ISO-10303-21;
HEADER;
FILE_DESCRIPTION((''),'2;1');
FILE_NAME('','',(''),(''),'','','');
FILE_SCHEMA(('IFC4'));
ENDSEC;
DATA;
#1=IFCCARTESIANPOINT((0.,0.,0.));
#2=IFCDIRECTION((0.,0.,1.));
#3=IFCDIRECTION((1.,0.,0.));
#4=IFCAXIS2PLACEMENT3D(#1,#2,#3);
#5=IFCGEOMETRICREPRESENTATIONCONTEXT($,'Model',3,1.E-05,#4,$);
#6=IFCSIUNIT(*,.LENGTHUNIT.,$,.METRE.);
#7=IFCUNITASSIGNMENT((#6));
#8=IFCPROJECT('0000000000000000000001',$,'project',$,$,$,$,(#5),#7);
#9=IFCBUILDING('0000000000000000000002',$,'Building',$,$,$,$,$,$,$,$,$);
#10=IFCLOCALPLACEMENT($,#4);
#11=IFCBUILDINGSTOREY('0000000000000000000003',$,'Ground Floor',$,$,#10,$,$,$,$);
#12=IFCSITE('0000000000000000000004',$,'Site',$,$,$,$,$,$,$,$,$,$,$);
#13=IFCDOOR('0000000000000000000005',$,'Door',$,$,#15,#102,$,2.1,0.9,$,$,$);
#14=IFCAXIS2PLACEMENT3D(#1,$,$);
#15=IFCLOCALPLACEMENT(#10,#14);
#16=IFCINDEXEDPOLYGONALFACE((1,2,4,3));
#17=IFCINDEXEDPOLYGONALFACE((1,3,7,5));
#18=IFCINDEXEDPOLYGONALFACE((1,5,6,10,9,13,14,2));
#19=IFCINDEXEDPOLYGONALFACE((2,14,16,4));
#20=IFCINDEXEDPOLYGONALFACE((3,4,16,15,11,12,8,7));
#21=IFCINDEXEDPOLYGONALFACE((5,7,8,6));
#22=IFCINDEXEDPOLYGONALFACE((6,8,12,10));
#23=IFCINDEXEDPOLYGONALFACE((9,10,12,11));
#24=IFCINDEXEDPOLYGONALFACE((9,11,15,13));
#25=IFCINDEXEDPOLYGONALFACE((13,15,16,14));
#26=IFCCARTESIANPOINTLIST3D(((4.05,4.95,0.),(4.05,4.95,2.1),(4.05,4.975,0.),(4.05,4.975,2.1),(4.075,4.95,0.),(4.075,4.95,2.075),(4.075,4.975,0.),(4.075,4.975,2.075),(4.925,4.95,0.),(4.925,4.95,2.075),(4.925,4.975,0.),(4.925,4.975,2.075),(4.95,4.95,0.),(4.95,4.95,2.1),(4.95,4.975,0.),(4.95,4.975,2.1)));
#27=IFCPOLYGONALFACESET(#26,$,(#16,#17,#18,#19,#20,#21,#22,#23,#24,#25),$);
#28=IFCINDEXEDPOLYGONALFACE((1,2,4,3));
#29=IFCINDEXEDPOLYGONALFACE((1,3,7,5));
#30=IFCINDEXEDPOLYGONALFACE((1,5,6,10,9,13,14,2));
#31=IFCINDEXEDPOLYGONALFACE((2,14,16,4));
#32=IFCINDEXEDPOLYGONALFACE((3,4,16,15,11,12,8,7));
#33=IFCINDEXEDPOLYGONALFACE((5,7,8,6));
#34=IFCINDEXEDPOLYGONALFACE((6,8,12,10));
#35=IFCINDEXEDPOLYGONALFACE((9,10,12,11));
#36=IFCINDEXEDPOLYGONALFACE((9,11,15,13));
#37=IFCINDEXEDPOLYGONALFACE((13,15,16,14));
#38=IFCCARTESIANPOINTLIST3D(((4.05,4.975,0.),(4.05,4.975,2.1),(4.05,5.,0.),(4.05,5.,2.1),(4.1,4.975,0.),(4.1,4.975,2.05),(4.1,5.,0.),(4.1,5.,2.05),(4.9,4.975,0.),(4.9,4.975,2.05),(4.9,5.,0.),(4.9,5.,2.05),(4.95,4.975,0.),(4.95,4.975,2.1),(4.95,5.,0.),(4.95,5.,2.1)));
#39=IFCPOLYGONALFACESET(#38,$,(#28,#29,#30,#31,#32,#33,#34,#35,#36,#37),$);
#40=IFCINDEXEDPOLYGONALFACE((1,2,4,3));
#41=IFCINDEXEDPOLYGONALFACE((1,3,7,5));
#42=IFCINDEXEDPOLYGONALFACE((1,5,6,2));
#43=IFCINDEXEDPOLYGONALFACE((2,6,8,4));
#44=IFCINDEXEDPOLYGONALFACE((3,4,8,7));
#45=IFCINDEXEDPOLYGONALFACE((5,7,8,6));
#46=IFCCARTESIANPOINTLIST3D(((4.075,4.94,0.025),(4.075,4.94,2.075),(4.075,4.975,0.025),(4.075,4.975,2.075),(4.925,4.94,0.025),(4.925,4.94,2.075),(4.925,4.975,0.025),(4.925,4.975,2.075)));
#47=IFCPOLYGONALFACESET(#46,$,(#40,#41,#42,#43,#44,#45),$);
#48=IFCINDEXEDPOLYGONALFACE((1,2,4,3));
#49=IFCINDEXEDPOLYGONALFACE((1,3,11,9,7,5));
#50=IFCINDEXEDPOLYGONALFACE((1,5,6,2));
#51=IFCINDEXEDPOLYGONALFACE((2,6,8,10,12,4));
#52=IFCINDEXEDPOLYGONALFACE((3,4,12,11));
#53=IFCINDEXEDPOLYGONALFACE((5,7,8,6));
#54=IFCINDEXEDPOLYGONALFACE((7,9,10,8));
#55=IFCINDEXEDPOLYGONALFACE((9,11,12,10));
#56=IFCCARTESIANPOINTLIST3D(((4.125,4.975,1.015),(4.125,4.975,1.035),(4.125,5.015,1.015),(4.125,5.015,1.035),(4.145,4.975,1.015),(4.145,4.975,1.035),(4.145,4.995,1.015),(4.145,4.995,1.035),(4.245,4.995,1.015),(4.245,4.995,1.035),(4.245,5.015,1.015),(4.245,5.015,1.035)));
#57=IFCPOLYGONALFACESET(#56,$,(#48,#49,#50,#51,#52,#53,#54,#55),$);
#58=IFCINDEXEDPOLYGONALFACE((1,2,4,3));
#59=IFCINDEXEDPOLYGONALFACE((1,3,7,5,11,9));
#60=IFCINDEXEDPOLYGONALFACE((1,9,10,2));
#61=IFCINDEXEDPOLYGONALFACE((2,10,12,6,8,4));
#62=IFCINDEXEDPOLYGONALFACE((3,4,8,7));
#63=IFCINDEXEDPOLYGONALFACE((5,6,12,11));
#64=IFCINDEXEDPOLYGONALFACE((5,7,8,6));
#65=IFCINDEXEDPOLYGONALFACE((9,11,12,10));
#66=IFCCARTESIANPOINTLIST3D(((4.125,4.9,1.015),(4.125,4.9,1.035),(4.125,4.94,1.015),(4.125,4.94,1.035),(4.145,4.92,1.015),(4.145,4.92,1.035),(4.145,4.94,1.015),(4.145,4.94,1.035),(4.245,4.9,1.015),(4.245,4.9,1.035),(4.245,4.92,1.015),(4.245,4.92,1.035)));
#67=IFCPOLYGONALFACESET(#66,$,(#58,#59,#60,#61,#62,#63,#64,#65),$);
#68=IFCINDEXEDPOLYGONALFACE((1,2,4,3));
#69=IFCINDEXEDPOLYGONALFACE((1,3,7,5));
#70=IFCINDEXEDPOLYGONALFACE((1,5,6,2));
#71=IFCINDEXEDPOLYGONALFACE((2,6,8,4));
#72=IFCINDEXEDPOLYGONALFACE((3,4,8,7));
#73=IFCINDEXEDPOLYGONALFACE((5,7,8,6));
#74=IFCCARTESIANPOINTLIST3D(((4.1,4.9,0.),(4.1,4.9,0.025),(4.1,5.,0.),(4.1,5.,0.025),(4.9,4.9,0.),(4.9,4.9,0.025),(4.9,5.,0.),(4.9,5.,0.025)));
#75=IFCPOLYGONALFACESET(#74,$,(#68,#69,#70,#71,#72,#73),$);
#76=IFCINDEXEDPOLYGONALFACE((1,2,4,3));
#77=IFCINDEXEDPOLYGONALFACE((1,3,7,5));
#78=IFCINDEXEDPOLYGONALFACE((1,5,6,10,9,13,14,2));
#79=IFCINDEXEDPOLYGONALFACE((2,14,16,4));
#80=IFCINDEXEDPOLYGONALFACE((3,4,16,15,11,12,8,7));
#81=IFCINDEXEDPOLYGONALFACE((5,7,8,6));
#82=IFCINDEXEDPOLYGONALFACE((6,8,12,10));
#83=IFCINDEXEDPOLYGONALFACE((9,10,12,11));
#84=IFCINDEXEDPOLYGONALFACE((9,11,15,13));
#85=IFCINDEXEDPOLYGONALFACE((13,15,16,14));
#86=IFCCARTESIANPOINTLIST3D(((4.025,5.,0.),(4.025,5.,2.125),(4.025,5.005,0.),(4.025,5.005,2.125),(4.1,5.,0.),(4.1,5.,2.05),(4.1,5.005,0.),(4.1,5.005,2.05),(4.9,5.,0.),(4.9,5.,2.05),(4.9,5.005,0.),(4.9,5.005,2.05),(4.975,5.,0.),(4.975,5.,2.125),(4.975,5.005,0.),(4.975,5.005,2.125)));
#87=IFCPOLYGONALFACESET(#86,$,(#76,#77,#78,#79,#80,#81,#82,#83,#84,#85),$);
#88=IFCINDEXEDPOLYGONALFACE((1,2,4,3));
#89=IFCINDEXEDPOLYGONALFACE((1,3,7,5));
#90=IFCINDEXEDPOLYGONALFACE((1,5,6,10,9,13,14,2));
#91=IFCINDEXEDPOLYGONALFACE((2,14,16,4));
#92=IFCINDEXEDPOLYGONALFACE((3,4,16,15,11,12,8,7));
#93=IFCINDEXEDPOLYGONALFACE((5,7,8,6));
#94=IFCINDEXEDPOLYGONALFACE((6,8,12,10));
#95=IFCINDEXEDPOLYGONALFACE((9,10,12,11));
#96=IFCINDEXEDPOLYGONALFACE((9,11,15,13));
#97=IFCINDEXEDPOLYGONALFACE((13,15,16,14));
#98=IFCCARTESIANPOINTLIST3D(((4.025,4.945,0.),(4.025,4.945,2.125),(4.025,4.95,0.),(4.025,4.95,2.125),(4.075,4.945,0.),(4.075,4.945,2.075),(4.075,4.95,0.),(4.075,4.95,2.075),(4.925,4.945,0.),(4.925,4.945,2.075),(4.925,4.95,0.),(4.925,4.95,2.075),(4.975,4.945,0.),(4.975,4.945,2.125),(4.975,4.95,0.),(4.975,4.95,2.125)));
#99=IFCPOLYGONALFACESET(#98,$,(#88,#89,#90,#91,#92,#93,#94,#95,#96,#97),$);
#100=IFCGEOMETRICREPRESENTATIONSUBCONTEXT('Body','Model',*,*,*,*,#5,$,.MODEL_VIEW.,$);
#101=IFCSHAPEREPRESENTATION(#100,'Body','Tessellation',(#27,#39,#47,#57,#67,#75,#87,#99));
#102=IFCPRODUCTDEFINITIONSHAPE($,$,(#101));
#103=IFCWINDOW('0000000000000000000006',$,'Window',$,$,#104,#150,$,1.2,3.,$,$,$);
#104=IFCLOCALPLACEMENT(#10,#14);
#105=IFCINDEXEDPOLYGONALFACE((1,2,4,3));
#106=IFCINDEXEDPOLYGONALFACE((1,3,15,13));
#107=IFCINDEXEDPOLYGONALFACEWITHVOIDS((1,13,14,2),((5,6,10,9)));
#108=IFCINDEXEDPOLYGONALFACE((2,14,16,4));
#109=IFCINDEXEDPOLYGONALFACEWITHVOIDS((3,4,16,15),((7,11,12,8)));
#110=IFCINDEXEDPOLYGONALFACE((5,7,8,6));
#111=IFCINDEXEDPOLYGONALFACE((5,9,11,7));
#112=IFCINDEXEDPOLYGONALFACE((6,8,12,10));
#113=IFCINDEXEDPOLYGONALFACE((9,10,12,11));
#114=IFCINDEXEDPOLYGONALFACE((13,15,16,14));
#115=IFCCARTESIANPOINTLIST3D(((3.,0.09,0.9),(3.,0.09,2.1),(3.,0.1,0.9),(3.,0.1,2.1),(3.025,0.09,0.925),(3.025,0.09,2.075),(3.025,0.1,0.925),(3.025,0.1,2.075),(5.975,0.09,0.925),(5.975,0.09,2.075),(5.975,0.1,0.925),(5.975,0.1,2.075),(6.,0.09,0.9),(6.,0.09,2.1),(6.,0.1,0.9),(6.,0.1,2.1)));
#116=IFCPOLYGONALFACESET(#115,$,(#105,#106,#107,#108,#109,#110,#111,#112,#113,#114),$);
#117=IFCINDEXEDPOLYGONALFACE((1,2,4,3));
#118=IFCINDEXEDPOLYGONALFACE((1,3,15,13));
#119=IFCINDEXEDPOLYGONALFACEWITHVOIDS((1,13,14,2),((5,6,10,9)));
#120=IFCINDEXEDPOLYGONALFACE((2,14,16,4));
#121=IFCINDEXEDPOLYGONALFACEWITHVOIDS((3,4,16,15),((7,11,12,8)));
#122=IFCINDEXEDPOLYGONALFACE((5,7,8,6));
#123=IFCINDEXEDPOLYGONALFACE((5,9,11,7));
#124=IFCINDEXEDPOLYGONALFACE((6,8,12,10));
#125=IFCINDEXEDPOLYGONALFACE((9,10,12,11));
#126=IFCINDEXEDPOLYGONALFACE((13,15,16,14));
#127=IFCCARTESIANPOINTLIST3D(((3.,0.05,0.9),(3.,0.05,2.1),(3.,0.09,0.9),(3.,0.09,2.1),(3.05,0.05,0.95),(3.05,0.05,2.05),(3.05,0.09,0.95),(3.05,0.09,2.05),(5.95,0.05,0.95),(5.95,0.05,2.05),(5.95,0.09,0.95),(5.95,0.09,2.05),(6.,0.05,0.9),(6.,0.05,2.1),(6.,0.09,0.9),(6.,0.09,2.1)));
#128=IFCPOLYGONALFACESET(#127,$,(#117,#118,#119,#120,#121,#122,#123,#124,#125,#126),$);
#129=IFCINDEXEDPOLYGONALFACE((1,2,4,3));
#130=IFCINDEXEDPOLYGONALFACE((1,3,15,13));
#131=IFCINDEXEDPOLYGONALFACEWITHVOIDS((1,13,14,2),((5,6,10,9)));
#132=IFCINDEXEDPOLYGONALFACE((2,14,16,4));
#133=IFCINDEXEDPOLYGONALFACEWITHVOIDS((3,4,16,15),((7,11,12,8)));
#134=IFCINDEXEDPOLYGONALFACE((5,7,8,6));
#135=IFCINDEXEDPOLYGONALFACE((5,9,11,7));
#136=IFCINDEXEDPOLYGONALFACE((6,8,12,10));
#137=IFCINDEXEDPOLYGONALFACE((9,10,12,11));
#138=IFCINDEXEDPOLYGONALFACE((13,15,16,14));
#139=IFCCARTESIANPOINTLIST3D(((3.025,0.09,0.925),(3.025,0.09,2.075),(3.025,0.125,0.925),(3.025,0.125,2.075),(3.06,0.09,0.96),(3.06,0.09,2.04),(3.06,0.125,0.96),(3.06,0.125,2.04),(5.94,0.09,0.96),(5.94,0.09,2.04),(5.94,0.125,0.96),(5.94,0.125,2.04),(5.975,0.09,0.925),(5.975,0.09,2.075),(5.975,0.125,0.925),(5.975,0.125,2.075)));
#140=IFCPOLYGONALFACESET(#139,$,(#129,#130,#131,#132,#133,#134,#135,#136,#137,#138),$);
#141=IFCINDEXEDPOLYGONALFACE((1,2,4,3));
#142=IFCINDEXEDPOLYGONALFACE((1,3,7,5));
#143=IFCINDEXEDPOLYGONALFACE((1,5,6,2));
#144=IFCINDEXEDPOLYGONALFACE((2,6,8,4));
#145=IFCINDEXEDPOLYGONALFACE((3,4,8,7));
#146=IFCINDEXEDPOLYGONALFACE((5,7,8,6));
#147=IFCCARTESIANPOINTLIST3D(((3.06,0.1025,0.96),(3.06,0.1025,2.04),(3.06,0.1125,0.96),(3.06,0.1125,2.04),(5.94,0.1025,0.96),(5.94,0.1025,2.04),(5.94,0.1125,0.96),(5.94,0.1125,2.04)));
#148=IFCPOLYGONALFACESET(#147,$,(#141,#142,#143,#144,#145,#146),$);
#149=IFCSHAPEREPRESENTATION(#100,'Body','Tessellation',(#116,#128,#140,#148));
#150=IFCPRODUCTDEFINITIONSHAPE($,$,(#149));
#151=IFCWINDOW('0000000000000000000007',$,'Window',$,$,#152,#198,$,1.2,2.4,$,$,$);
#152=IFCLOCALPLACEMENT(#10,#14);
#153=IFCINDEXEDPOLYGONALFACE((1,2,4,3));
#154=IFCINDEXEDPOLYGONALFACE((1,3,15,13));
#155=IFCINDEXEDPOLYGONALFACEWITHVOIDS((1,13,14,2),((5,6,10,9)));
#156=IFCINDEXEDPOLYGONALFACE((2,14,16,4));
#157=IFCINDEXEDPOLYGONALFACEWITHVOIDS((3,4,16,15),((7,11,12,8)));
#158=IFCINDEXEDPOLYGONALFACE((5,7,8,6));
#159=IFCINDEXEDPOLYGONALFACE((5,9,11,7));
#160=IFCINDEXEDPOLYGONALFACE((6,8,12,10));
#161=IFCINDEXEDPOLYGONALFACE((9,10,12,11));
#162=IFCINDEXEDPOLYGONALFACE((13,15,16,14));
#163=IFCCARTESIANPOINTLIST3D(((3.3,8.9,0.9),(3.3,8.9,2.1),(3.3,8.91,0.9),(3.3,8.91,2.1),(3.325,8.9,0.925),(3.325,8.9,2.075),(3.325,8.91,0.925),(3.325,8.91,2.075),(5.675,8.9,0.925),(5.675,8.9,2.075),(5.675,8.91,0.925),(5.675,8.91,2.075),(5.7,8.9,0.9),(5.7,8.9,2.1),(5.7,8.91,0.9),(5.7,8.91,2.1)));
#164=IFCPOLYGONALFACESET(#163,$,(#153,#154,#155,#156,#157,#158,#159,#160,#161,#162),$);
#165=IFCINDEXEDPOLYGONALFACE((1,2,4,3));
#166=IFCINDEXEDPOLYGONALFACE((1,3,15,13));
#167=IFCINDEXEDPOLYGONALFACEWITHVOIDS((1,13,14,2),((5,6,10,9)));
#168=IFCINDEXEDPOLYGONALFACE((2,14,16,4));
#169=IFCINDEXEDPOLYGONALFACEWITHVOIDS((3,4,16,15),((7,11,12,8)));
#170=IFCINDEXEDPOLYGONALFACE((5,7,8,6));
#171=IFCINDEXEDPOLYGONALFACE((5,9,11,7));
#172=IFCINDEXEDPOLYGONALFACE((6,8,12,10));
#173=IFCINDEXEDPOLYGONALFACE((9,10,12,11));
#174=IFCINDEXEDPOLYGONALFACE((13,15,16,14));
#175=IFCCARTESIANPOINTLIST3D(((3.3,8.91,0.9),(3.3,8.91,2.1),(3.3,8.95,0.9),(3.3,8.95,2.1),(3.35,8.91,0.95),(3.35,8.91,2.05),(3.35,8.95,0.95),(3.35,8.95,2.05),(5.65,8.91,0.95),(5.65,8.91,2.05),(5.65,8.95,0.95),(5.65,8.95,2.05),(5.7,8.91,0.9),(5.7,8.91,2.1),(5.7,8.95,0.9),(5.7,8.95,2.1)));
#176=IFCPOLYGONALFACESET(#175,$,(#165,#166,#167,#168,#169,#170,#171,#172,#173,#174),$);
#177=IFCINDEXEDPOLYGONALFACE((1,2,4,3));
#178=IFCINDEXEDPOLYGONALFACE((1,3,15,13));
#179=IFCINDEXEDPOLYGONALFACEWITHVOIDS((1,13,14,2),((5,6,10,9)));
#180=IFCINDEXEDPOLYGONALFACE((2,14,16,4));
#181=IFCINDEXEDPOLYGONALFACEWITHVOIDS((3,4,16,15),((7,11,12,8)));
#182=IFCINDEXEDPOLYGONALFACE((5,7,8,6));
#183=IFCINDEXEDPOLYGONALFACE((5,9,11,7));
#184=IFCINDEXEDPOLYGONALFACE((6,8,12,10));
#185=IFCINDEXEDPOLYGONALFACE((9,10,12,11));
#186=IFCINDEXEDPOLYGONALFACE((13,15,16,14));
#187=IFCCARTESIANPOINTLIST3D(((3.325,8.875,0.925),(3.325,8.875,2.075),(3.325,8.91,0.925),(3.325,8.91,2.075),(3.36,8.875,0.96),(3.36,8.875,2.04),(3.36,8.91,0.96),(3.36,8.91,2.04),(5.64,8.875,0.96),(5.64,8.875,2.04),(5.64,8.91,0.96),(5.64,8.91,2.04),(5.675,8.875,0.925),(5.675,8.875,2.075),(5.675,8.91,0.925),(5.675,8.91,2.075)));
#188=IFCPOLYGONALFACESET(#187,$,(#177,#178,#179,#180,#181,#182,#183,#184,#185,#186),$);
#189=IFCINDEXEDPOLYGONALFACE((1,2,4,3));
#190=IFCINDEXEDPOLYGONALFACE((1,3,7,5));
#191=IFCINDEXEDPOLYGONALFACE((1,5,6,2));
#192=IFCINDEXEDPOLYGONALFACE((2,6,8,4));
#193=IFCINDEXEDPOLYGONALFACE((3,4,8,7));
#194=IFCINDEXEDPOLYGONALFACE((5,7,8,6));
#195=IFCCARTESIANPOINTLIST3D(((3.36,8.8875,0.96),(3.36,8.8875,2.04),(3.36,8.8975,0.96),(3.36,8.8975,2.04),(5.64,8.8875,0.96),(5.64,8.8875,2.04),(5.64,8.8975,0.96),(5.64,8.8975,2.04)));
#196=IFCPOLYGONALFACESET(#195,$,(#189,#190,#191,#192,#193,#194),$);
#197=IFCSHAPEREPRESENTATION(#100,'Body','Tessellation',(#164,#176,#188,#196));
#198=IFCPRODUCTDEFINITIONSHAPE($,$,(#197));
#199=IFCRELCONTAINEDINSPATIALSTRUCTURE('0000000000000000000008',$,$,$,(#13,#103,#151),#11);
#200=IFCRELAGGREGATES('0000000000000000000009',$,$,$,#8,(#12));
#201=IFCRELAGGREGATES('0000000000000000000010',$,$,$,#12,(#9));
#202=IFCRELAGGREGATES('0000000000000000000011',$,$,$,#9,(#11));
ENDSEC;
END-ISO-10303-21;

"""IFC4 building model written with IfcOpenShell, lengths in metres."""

from ifc_helpers import new_model, si_unit, frame, origin_with_axes, place, context, subcontext, project, spatial, line, indexed_curve, outline, extrude, element, save


model = new_model("IFC4")

# Units and contexts
model_context = context("Model", 3, precision=1e-05, world=origin_with_axes())
body_context = subcontext(model_context, "Body", "Model", "MODEL_VIEW")
ifc_project = project(units=[si_unit("LENGTHUNIT", "METRE")], contexts=[model_context])

# Site, building, storey
site = spatial("IfcSite", under=ifc_project, Name="Site")
building = spatial("IfcBuilding", under=site, Name="Building")
storey_placement = place(None, origin_with_axes())
storey = spatial("IfcBuildingStorey", under=building, at=storey_placement, Name="Ground Floor")

# Door
door_1_placement = place(storey_placement, frame((4.95, 5.0, 0.0), z_axis=(0.0, 0.0, 1.0), x_axis=(-1.0, 0.0, 0.0)))
element("IfcDoor", 1, at=door_1_placement, inside=storey, Name="Door", OverallHeight=2.1, OverallWidth=0.9, context=body_context, shape_type="SweptSolid", body=[
    extrude(outline(indexed_curve([(0.0, 0.0), (0.0, 2.1), (0.9, 2.1), (0.9, 0.0), (0.875, 0.0), (0.875, 2.075), (0.025, 2.075), (0.025, 0.0)], segments=[line(1, 2, 3, 4, 5, 6, 7, 8, 1)])), frame((0.0, 0.025, 0.0), z_axis=(0.0, -1.0, 0.0), x_axis=(1.0, 0.0, 0.0)), (0.0, 0.0, -1.0), 0.025),
    extrude(outline(indexed_curve([(0.0, 0.0), (0.0, 2.1), (0.9, 2.1), (0.9, 0.0), (0.85, 0.0), (0.85, 2.05), (0.05, 2.05), (0.05, 0.0)], segments=[line(1, 2, 3, 4, 5, 6, 7, 8, 1)])), frame((0.0, 0.0, 0.0), z_axis=(0.0, -1.0, 0.0), x_axis=(1.0, 0.0, 0.0)), (0.0, 0.0, -1.0), 0.025),
    extrude(outline(indexed_curve([(0.0, 0.0), (0.85, 0.0), (0.85, 0.035), (0.0, 0.035)], segments=[line(1, 2, 3, 4, 1)])), frame((0.025, 0.025, 0.025), z_axis=(0.0, 0.0, 1.0), x_axis=(1.0, 0.0, 0.0)), (0.0, 0.0, 1.0), 2.05),
    extrude(outline(indexed_curve([(0.0, 0.0), (0.0, -0.04), (-0.12, -0.04), (-0.12, -0.02), (-0.02, -0.02), (-0.02, 0.0)], segments=[line(1, 2, 3, 4, 5, 6, 1)])), frame((0.825, 0.025, 1.015), z_axis=(0.0, 0.0, 1.0), x_axis=(1.0, 0.0, 0.0)), (0.0, 0.0, 1.0), 0.02),
    extrude(outline(indexed_curve([(0.0, 0.0), (0.0, 0.04), (-0.12, 0.04), (-0.12, 0.02), (-0.02, 0.02), (-0.02, 0.0)], segments=[line(1, 2, 3, 4, 5, 6, 1)])), frame((0.825, 0.06, 1.015), z_axis=(0.0, 0.0, 1.0), x_axis=(1.0, 0.0, 0.0)), (0.0, 0.0, 1.0), 0.02),
    extrude(outline(indexed_curve([(0.0, 0.0), (0.8, 0.0), (0.8, 0.1), (0.0, 0.1)], segments=[line(1, 2, 3, 4, 1)])), frame((0.05, 0.0, 0.0), z_axis=(0.0, 0.0, 1.0), x_axis=(1.0, 0.0, 0.0)), (0.0, 0.0, 1.0), 0.025),
    extrude(outline(indexed_curve([(0.0, 0.0), (0.0, 2.125), (0.95, 2.125), (0.95, 0.0), (0.875, 0.0), (0.875, 2.05), (0.075, 2.05), (0.075, 0.0)], segments=[line(1, 2, 3, 4, 5, 6, 7, 8, 1)])), frame((-0.025, -0.005, 0.0), z_axis=(0.0, -1.0, 0.0), x_axis=(1.0, 0.0, 0.0)), (0.0, 0.0, -1.0), 0.005),
    extrude(outline(indexed_curve([(0.0, 0.0), (0.0, 2.125), (0.95, 2.125), (0.95, 0.0), (0.9, 0.0), (0.9, 2.075), (0.05, 2.075), (0.05, 0.0)], segments=[line(1, 2, 3, 4, 5, 6, 7, 8, 1)])), frame((-0.025, 0.05, 0.0), z_axis=(0.0, -1.0, 0.0), x_axis=(1.0, 0.0, 0.0)), (0.0, 0.0, -1.0), 0.005),
])

# Windows
window_1_placement = place(storey_placement, frame((3.0, 0.0, 0.9), z_axis=(0.0, 0.0, 1.0), x_axis=(1.0, 0.0, 0.0)))
element("IfcWindow", 2, at=window_1_placement, inside=storey, Name="Window", OverallHeight=1.2, OverallWidth=3.0, context=body_context, shape_type="SweptSolid", body=[
    extrude(outline(indexed_curve([(0.0, 0.0), (3.0, 0.0), (3.0, 1.2), (0.0, 1.2)], segments=[line(1, 2, 3, 4, 1)]), holes=[indexed_curve([(0.025, 0.025), (2.975, 0.025), (2.975, 1.175), (0.025, 1.175)], segments=[line(1, 2, 3, 4, 1)])]), frame((0.0, 0.09, 0.0), z_axis=(0.0, -1.0, 0.0), x_axis=(1.0, 0.0, 0.0)), (0.0, 0.0, -1.0), 0.01),
    extrude(outline(indexed_curve([(0.0, 0.0), (3.0, 0.0), (3.0, 1.2), (0.0, 1.2)], segments=[line(1, 2, 3, 4, 1)]), holes=[indexed_curve([(0.05, 0.05), (2.95, 0.05), (2.95, 1.15), (0.05, 1.15)], segments=[line(1, 2, 3, 4, 1)])]), frame((0.0, 0.05, 0.0), z_axis=(0.0, -1.0, 0.0), x_axis=(1.0, 0.0, 0.0)), (0.0, 0.0, -1.0), 0.04),
    extrude(outline(indexed_curve([(0.0, 0.0), (2.95, 0.0), (2.95, 1.15), (0.0, 1.15)], segments=[line(1, 2, 3, 4, 1)]), holes=[indexed_curve([(0.035, 0.035), (2.915, 0.035), (2.915, 1.115), (0.035, 1.115)], segments=[line(1, 2, 3, 4, 1)])]), frame((0.025, 0.09, 0.025), z_axis=(0.0, -1.0, 0.0), x_axis=(1.0, 0.0, 0.0)), (0.0, 0.0, -1.0), 0.035),
    extrude(outline(indexed_curve([(0.035, 0.035), (2.915, 0.035), (2.915, 1.115), (0.035, 1.115)], segments=[line(1, 2, 3, 4, 1)])), frame((0.025, 0.1025, 0.025), z_axis=(0.0, -1.0, 0.0), x_axis=(1.0, 0.0, 0.0)), (0.0, 0.0, -1.0), 0.01),
])
window_2_placement = place(storey_placement, frame((5.7, 9.0, 0.9), z_axis=(0.0, 0.0, 1.0), x_axis=(-1.0, 0.0, 0.0)))
element("IfcWindow", 3, at=window_2_placement, inside=storey, Name="Window", OverallHeight=1.2, OverallWidth=2.4, context=body_context, shape_type="SweptSolid", body=[
    extrude(outline(indexed_curve([(0.0, 0.0), (2.4, 0.0), (2.4, 1.2), (0.0, 1.2)], segments=[line(1, 2, 3, 4, 1)]), holes=[indexed_curve([(0.025, 0.025), (2.375, 0.025), (2.375, 1.175), (0.025, 1.175)], segments=[line(1, 2, 3, 4, 1)])]), frame((0.0, 0.09, 0.0), z_axis=(0.0, -1.0, 0.0), x_axis=(1.0, 0.0, 0.0)), (0.0, 0.0, -1.0), 0.01),
    extrude(outline(indexed_curve([(0.0, 0.0), (2.4, 0.0), (2.4, 1.2), (0.0, 1.2)], segments=[line(1, 2, 3, 4, 1)]), holes=[indexed_curve([(0.05, 0.05), (2.35, 0.05), (2.35, 1.15), (0.05, 1.15)], segments=[line(1, 2, 3, 4, 1)])]), frame((0.0, 0.05, 0.0), z_axis=(0.0, -1.0, 0.0), x_axis=(1.0, 0.0, 0.0)), (0.0, 0.0, -1.0), 0.04),
    extrude(outline(indexed_curve([(0.0, 0.0), (2.35, 0.0), (2.35, 1.15), (0.0, 1.15)], segments=[line(1, 2, 3, 4, 1)]), holes=[indexed_curve([(0.035, 0.035), (2.315, 0.035), (2.315, 1.115), (0.035, 1.115)], segments=[line(1, 2, 3, 4, 1)])]), frame((0.025, 0.09, 0.025), z_axis=(0.0, -1.0, 0.0), x_axis=(1.0, 0.0, 0.0)), (0.0, 0.0, -1.0), 0.035),
    extrude(outline(indexed_curve([(0.035, 0.035), (2.315, 0.035), (2.315, 1.115), (0.035, 1.115)], segments=[line(1, 2, 3, 4, 1)])), frame((0.025, 0.1025, 0.025), z_axis=(0.0, -1.0, 0.0), x_axis=(1.0, 0.0, 0.0)), (0.0, 0.0, -1.0), 0.01),
])

save(model, "model.ifc")
